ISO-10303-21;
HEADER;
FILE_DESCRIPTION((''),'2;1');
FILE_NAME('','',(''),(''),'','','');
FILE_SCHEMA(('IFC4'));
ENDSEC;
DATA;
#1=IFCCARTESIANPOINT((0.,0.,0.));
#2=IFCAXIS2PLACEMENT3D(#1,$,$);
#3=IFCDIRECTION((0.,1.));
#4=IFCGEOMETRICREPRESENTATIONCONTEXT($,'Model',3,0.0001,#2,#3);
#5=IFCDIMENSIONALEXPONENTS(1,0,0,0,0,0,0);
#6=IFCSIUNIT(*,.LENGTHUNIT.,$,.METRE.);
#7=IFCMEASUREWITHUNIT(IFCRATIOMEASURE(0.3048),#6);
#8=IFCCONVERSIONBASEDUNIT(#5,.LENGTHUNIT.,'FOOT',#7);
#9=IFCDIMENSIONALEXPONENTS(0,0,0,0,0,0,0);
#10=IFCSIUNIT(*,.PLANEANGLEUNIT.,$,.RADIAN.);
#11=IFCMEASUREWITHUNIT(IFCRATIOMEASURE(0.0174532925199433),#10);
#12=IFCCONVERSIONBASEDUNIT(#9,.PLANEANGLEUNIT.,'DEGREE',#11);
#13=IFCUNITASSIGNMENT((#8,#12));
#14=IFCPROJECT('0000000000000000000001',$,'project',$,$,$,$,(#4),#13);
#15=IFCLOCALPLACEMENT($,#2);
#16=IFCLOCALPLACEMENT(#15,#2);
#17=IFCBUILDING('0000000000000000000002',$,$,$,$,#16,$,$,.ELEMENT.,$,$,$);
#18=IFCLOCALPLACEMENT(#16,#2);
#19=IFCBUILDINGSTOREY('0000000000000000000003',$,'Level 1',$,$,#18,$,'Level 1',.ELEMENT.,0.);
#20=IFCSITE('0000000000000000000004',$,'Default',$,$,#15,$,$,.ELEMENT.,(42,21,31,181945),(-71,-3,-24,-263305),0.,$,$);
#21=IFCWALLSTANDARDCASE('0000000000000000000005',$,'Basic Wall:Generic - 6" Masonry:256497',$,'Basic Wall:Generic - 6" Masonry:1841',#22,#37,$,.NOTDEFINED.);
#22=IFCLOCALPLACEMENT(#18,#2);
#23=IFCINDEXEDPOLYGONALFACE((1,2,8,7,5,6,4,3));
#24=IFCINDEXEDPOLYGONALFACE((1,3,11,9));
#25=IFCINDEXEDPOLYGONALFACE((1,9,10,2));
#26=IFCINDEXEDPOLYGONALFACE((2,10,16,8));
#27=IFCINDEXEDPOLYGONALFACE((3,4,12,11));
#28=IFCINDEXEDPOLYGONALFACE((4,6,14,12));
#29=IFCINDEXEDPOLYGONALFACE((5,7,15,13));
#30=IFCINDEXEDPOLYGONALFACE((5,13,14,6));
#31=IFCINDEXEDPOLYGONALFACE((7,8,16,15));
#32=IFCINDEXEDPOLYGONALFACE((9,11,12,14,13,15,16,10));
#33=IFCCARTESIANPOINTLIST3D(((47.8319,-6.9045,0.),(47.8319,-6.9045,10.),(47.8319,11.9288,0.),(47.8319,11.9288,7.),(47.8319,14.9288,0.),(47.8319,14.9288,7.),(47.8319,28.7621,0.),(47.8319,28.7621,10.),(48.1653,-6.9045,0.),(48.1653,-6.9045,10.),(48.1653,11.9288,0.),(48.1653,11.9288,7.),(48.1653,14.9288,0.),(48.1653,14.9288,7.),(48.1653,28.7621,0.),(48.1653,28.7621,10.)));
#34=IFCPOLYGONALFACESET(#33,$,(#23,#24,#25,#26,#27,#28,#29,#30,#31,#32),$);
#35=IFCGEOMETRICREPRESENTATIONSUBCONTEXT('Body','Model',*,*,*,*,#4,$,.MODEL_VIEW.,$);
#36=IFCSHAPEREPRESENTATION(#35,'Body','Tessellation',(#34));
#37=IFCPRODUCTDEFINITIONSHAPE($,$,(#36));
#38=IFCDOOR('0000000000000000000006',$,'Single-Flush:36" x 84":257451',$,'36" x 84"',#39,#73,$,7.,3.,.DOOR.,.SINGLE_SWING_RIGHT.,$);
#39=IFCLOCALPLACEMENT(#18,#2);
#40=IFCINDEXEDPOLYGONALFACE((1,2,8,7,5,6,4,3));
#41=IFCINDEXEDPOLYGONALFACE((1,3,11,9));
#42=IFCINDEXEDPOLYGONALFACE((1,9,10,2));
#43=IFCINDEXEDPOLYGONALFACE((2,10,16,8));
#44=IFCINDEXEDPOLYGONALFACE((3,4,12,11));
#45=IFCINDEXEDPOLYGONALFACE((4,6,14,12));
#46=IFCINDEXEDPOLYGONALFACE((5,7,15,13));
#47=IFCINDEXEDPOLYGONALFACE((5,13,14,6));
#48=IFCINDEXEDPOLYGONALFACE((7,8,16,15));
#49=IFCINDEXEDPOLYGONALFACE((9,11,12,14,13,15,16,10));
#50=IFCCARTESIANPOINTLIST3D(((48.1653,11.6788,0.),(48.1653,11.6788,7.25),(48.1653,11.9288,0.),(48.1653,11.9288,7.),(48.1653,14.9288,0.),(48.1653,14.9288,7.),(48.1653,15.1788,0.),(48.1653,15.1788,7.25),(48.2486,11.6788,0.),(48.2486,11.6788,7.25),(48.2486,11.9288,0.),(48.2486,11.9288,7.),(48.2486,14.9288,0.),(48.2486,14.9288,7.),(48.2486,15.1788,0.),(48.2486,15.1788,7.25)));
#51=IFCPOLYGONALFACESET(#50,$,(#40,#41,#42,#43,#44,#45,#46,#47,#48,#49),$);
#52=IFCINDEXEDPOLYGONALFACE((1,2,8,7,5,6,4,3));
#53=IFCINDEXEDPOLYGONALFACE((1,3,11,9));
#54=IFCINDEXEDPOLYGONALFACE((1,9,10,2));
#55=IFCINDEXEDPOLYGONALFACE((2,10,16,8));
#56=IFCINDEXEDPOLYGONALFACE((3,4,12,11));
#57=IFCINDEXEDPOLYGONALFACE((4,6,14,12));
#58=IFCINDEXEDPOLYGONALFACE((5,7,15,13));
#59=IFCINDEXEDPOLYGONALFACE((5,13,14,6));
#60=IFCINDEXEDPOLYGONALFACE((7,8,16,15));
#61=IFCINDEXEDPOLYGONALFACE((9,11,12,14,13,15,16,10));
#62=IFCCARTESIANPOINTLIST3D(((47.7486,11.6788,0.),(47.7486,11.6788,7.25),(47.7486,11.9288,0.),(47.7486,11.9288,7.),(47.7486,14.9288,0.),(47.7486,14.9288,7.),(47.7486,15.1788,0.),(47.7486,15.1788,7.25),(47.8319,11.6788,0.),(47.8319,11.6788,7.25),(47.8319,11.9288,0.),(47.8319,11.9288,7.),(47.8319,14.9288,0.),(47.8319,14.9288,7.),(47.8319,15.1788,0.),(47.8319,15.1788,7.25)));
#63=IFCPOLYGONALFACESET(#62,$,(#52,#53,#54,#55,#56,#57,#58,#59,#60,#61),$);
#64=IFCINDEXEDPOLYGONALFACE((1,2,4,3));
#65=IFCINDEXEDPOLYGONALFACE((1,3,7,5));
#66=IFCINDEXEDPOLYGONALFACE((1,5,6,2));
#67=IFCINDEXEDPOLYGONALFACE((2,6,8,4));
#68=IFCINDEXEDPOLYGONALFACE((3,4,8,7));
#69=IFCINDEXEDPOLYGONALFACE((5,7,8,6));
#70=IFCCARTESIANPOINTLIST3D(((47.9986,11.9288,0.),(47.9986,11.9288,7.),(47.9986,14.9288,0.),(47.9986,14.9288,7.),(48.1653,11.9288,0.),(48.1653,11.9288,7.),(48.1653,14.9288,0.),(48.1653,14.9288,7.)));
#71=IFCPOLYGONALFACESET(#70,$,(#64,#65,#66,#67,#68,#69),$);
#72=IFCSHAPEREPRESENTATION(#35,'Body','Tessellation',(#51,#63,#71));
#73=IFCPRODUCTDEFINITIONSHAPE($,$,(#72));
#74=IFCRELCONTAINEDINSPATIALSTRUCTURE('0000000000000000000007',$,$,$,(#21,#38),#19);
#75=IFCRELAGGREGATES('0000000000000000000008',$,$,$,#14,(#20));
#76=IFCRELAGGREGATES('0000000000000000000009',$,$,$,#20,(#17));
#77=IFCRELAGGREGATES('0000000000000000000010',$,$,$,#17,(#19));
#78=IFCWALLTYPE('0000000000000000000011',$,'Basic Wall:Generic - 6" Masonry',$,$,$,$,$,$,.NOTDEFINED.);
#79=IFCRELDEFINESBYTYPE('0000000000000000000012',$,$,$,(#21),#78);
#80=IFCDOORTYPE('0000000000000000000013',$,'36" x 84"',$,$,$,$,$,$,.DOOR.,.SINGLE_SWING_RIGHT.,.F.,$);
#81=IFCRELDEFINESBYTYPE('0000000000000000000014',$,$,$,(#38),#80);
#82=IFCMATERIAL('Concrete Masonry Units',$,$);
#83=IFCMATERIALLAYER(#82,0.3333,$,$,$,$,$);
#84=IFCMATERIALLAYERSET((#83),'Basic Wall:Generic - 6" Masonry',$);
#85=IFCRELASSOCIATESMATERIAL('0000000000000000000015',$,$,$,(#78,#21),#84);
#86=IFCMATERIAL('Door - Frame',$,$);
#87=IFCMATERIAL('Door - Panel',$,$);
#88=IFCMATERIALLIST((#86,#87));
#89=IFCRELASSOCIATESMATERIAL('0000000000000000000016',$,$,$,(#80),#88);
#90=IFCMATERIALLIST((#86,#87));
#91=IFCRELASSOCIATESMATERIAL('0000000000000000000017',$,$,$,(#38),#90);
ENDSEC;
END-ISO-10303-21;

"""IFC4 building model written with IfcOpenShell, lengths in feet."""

from ifc_helpers import new_model, entity, si_unit, converted_unit, direction, frame, frame_2d, origin, place, context, subcontext, project, spatial, polyline, rectangle, outline, extrude, source, transform, mapped, material, material_list, layer, layer_set, layer_usage, type_object, type_shapes, element, fill, save


model = new_model("IFC4")

# Units and contexts
model_context = context("Model", 3, precision=0.0001, world=origin(), true_north=direction((0.0, 1.0)))
body_context = subcontext(model_context, "Body", "Model", "MODEL_VIEW")
ifc_project = project(units=[converted_unit("LENGTHUNIT", "FOOT", entity("IfcRatioMeasure", 0.3048), si_unit("LENGTHUNIT", "METRE"), dimensions=[1, 0, 0, 0, 0, 0, 0]), converted_unit("PLANEANGLEUNIT", "DEGREE", entity("IfcRatioMeasure", 0.0174532925199433), si_unit("PLANEANGLEUNIT", "RADIAN"), dimensions=[0, 0, 0, 0, 0, 0, 0])], contexts=[model_context])

# Site, building, storey
site_placement = place(None, origin())
site = spatial("IfcSite", under=ifc_project, at=site_placement, Name="Default", CompositionType="ELEMENT", RefLatitude=(42, 21, 31, 181945), RefLongitude=(-71, -3, -24, -263305), RefElevation=0.0)
building_placement = place(site_placement, origin())
building = spatial("IfcBuilding", under=site, at=building_placement, CompositionType="ELEMENT")
storey_placement = place(building_placement, origin())
storey = spatial("IfcBuildingStorey", under=building, at=storey_placement, Name="Level 1", LongName="Level 1", CompositionType="ELEMENT", Elevation=0.0)

# Shared definitions
wall_placement = place(storey_placement, frame((47.9986, 28.7621, 0.0), z_axis=(0.0, 0.0, 1.0), x_axis=(0.0, -1.0, 0.0)))

# Wall, opening, door
ifc_material_1 = material(Name="Concrete Masonry Units")
ifc_layer = layer(ifc_material_1, 0.3333)
ifc_layer_set = layer_set([ifc_layer], Name="Basic Wall:Generic - 6\" Masonry")
ifc_layer_usage = layer_usage(ifc_layer_set, "AXIS2", "NEGATIVE", 0.1667)
wall_type = type_object("IfcWallType", Name="Basic Wall:Generic - 6\" Masonry", PredefinedType="NOTDEFINED", material=ifc_layer_set)
wall = element("IfcWallStandardCase", 1, at=wall_placement, inside=storey, type_object=wall_type, material=ifc_layer_usage, Name="Basic Wall:Generic - 6\" Masonry:256497", ObjectType="Basic Wall:Generic - 6\" Masonry:1841", PredefinedType="NOTDEFINED", context=body_context, shape_type="SweptSolid", body=[
    extrude(rectangle(XDim=35.6667, YDim=0.3333, at=frame_2d((17.8333, 0.0), x_axis=(-1.0, 0.0))), origin(), (0.0, 0.0, 1.0), 10.0),
])
opening_placement = place(wall_placement, frame((13.8333, -0.1667, 0.0)))
opening = element("IfcOpeningElement", 2, at=opening_placement, cuts=wall, ObjectType="Opening", PredefinedType="OPENING", context=body_context, shape_type="SweptSolid", body=[
    extrude(rectangle(XDim=3.0, YDim=7.0, at=frame_2d((3.5, 1.5), x_axis=(0.0, 1.0))), frame((0.0, 0.0, 0.0), z_axis=(0.0, 1.0, 0.0), x_axis=(0.0, 0.0, 1.0)), (0.0, 0.0, 1.0), 0.3333),
])
ifc_material_2 = material(Name="Door - Frame")
ifc_material_3 = material(Name="Door - Panel")
ifc_material_list_1 = material_list([ifc_material_2, ifc_material_3])
ifc_material_list_2 = material_list([ifc_material_2, ifc_material_3])
door_type = type_object("IfcDoorType", Name="36\" x 84\"", OperationType="SINGLE_SWING_RIGHT", ParameterTakesPrecedence=False, PredefinedType="DOOR", material=ifc_material_list_2)
shared_shape = source(origin(), body_context, "Body", "SweptSolid", [
    extrude(outline(polyline([(-1.75, -3.6875), (1.75, -3.6875), (1.75, 3.5625), (1.5, 3.5625), (1.5, -3.4375), (-1.5, -3.4375), (-1.5, 3.5625), (-1.75, 3.5625), (-1.75, -3.6875)])), frame((1.5, 0.3333, 3.5625), z_axis=(0.0, 1.0, 0.0), x_axis=(1.0, 0.0, 0.0)), (0.0, 0.0, 1.0), 0.0833),
    extrude(outline(polyline([(-3.6875, -1.75), (3.5625, -1.75), (3.5625, -1.5), (-3.4375, -1.5), (-3.4375, 1.5), (3.5625, 1.5), (3.5625, 1.75), (-3.6875, 1.75), (-3.6875, -1.75)])), frame((1.5, -0.0833, 3.5625), z_axis=(0.0, 1.0, 0.0), x_axis=(0.0, 0.0, -1.0)), (0.0, 0.0, 1.0), 0.0833),
    extrude(rectangle(XDim=0.1667, YDim=3.0, at=frame_2d((0.0, 0.0), x_axis=(1.0, 0.0))), frame((1.5, 0.25, 0.0), z_axis=(0.0, 0.0, 1.0), x_axis=(0.0, 1.0, 0.0)), (0.0, 0.0, 1.0), 7.0),
])
type_shapes(door_type, [shared_shape])
door_placement = place(opening_placement, origin())
door = element("IfcDoor", 3, at=door_placement, inside=storey, type_object=door_type, material=ifc_material_list_1, Name="Single-Flush:36\" x 84\":257451", ObjectType="36\" x 84\"", OperationType="SINGLE_SWING_RIGHT", OverallHeight=7.0, OverallWidth=3.0, PredefinedType="DOOR", context=body_context, shape_type="MappedRepresentation", body=[
    mapped(shared_shape, transform((0.0, 0.0, 0.0), scale=1.0)),
])
fill(opening, door)

save(model, "model.ifc")
